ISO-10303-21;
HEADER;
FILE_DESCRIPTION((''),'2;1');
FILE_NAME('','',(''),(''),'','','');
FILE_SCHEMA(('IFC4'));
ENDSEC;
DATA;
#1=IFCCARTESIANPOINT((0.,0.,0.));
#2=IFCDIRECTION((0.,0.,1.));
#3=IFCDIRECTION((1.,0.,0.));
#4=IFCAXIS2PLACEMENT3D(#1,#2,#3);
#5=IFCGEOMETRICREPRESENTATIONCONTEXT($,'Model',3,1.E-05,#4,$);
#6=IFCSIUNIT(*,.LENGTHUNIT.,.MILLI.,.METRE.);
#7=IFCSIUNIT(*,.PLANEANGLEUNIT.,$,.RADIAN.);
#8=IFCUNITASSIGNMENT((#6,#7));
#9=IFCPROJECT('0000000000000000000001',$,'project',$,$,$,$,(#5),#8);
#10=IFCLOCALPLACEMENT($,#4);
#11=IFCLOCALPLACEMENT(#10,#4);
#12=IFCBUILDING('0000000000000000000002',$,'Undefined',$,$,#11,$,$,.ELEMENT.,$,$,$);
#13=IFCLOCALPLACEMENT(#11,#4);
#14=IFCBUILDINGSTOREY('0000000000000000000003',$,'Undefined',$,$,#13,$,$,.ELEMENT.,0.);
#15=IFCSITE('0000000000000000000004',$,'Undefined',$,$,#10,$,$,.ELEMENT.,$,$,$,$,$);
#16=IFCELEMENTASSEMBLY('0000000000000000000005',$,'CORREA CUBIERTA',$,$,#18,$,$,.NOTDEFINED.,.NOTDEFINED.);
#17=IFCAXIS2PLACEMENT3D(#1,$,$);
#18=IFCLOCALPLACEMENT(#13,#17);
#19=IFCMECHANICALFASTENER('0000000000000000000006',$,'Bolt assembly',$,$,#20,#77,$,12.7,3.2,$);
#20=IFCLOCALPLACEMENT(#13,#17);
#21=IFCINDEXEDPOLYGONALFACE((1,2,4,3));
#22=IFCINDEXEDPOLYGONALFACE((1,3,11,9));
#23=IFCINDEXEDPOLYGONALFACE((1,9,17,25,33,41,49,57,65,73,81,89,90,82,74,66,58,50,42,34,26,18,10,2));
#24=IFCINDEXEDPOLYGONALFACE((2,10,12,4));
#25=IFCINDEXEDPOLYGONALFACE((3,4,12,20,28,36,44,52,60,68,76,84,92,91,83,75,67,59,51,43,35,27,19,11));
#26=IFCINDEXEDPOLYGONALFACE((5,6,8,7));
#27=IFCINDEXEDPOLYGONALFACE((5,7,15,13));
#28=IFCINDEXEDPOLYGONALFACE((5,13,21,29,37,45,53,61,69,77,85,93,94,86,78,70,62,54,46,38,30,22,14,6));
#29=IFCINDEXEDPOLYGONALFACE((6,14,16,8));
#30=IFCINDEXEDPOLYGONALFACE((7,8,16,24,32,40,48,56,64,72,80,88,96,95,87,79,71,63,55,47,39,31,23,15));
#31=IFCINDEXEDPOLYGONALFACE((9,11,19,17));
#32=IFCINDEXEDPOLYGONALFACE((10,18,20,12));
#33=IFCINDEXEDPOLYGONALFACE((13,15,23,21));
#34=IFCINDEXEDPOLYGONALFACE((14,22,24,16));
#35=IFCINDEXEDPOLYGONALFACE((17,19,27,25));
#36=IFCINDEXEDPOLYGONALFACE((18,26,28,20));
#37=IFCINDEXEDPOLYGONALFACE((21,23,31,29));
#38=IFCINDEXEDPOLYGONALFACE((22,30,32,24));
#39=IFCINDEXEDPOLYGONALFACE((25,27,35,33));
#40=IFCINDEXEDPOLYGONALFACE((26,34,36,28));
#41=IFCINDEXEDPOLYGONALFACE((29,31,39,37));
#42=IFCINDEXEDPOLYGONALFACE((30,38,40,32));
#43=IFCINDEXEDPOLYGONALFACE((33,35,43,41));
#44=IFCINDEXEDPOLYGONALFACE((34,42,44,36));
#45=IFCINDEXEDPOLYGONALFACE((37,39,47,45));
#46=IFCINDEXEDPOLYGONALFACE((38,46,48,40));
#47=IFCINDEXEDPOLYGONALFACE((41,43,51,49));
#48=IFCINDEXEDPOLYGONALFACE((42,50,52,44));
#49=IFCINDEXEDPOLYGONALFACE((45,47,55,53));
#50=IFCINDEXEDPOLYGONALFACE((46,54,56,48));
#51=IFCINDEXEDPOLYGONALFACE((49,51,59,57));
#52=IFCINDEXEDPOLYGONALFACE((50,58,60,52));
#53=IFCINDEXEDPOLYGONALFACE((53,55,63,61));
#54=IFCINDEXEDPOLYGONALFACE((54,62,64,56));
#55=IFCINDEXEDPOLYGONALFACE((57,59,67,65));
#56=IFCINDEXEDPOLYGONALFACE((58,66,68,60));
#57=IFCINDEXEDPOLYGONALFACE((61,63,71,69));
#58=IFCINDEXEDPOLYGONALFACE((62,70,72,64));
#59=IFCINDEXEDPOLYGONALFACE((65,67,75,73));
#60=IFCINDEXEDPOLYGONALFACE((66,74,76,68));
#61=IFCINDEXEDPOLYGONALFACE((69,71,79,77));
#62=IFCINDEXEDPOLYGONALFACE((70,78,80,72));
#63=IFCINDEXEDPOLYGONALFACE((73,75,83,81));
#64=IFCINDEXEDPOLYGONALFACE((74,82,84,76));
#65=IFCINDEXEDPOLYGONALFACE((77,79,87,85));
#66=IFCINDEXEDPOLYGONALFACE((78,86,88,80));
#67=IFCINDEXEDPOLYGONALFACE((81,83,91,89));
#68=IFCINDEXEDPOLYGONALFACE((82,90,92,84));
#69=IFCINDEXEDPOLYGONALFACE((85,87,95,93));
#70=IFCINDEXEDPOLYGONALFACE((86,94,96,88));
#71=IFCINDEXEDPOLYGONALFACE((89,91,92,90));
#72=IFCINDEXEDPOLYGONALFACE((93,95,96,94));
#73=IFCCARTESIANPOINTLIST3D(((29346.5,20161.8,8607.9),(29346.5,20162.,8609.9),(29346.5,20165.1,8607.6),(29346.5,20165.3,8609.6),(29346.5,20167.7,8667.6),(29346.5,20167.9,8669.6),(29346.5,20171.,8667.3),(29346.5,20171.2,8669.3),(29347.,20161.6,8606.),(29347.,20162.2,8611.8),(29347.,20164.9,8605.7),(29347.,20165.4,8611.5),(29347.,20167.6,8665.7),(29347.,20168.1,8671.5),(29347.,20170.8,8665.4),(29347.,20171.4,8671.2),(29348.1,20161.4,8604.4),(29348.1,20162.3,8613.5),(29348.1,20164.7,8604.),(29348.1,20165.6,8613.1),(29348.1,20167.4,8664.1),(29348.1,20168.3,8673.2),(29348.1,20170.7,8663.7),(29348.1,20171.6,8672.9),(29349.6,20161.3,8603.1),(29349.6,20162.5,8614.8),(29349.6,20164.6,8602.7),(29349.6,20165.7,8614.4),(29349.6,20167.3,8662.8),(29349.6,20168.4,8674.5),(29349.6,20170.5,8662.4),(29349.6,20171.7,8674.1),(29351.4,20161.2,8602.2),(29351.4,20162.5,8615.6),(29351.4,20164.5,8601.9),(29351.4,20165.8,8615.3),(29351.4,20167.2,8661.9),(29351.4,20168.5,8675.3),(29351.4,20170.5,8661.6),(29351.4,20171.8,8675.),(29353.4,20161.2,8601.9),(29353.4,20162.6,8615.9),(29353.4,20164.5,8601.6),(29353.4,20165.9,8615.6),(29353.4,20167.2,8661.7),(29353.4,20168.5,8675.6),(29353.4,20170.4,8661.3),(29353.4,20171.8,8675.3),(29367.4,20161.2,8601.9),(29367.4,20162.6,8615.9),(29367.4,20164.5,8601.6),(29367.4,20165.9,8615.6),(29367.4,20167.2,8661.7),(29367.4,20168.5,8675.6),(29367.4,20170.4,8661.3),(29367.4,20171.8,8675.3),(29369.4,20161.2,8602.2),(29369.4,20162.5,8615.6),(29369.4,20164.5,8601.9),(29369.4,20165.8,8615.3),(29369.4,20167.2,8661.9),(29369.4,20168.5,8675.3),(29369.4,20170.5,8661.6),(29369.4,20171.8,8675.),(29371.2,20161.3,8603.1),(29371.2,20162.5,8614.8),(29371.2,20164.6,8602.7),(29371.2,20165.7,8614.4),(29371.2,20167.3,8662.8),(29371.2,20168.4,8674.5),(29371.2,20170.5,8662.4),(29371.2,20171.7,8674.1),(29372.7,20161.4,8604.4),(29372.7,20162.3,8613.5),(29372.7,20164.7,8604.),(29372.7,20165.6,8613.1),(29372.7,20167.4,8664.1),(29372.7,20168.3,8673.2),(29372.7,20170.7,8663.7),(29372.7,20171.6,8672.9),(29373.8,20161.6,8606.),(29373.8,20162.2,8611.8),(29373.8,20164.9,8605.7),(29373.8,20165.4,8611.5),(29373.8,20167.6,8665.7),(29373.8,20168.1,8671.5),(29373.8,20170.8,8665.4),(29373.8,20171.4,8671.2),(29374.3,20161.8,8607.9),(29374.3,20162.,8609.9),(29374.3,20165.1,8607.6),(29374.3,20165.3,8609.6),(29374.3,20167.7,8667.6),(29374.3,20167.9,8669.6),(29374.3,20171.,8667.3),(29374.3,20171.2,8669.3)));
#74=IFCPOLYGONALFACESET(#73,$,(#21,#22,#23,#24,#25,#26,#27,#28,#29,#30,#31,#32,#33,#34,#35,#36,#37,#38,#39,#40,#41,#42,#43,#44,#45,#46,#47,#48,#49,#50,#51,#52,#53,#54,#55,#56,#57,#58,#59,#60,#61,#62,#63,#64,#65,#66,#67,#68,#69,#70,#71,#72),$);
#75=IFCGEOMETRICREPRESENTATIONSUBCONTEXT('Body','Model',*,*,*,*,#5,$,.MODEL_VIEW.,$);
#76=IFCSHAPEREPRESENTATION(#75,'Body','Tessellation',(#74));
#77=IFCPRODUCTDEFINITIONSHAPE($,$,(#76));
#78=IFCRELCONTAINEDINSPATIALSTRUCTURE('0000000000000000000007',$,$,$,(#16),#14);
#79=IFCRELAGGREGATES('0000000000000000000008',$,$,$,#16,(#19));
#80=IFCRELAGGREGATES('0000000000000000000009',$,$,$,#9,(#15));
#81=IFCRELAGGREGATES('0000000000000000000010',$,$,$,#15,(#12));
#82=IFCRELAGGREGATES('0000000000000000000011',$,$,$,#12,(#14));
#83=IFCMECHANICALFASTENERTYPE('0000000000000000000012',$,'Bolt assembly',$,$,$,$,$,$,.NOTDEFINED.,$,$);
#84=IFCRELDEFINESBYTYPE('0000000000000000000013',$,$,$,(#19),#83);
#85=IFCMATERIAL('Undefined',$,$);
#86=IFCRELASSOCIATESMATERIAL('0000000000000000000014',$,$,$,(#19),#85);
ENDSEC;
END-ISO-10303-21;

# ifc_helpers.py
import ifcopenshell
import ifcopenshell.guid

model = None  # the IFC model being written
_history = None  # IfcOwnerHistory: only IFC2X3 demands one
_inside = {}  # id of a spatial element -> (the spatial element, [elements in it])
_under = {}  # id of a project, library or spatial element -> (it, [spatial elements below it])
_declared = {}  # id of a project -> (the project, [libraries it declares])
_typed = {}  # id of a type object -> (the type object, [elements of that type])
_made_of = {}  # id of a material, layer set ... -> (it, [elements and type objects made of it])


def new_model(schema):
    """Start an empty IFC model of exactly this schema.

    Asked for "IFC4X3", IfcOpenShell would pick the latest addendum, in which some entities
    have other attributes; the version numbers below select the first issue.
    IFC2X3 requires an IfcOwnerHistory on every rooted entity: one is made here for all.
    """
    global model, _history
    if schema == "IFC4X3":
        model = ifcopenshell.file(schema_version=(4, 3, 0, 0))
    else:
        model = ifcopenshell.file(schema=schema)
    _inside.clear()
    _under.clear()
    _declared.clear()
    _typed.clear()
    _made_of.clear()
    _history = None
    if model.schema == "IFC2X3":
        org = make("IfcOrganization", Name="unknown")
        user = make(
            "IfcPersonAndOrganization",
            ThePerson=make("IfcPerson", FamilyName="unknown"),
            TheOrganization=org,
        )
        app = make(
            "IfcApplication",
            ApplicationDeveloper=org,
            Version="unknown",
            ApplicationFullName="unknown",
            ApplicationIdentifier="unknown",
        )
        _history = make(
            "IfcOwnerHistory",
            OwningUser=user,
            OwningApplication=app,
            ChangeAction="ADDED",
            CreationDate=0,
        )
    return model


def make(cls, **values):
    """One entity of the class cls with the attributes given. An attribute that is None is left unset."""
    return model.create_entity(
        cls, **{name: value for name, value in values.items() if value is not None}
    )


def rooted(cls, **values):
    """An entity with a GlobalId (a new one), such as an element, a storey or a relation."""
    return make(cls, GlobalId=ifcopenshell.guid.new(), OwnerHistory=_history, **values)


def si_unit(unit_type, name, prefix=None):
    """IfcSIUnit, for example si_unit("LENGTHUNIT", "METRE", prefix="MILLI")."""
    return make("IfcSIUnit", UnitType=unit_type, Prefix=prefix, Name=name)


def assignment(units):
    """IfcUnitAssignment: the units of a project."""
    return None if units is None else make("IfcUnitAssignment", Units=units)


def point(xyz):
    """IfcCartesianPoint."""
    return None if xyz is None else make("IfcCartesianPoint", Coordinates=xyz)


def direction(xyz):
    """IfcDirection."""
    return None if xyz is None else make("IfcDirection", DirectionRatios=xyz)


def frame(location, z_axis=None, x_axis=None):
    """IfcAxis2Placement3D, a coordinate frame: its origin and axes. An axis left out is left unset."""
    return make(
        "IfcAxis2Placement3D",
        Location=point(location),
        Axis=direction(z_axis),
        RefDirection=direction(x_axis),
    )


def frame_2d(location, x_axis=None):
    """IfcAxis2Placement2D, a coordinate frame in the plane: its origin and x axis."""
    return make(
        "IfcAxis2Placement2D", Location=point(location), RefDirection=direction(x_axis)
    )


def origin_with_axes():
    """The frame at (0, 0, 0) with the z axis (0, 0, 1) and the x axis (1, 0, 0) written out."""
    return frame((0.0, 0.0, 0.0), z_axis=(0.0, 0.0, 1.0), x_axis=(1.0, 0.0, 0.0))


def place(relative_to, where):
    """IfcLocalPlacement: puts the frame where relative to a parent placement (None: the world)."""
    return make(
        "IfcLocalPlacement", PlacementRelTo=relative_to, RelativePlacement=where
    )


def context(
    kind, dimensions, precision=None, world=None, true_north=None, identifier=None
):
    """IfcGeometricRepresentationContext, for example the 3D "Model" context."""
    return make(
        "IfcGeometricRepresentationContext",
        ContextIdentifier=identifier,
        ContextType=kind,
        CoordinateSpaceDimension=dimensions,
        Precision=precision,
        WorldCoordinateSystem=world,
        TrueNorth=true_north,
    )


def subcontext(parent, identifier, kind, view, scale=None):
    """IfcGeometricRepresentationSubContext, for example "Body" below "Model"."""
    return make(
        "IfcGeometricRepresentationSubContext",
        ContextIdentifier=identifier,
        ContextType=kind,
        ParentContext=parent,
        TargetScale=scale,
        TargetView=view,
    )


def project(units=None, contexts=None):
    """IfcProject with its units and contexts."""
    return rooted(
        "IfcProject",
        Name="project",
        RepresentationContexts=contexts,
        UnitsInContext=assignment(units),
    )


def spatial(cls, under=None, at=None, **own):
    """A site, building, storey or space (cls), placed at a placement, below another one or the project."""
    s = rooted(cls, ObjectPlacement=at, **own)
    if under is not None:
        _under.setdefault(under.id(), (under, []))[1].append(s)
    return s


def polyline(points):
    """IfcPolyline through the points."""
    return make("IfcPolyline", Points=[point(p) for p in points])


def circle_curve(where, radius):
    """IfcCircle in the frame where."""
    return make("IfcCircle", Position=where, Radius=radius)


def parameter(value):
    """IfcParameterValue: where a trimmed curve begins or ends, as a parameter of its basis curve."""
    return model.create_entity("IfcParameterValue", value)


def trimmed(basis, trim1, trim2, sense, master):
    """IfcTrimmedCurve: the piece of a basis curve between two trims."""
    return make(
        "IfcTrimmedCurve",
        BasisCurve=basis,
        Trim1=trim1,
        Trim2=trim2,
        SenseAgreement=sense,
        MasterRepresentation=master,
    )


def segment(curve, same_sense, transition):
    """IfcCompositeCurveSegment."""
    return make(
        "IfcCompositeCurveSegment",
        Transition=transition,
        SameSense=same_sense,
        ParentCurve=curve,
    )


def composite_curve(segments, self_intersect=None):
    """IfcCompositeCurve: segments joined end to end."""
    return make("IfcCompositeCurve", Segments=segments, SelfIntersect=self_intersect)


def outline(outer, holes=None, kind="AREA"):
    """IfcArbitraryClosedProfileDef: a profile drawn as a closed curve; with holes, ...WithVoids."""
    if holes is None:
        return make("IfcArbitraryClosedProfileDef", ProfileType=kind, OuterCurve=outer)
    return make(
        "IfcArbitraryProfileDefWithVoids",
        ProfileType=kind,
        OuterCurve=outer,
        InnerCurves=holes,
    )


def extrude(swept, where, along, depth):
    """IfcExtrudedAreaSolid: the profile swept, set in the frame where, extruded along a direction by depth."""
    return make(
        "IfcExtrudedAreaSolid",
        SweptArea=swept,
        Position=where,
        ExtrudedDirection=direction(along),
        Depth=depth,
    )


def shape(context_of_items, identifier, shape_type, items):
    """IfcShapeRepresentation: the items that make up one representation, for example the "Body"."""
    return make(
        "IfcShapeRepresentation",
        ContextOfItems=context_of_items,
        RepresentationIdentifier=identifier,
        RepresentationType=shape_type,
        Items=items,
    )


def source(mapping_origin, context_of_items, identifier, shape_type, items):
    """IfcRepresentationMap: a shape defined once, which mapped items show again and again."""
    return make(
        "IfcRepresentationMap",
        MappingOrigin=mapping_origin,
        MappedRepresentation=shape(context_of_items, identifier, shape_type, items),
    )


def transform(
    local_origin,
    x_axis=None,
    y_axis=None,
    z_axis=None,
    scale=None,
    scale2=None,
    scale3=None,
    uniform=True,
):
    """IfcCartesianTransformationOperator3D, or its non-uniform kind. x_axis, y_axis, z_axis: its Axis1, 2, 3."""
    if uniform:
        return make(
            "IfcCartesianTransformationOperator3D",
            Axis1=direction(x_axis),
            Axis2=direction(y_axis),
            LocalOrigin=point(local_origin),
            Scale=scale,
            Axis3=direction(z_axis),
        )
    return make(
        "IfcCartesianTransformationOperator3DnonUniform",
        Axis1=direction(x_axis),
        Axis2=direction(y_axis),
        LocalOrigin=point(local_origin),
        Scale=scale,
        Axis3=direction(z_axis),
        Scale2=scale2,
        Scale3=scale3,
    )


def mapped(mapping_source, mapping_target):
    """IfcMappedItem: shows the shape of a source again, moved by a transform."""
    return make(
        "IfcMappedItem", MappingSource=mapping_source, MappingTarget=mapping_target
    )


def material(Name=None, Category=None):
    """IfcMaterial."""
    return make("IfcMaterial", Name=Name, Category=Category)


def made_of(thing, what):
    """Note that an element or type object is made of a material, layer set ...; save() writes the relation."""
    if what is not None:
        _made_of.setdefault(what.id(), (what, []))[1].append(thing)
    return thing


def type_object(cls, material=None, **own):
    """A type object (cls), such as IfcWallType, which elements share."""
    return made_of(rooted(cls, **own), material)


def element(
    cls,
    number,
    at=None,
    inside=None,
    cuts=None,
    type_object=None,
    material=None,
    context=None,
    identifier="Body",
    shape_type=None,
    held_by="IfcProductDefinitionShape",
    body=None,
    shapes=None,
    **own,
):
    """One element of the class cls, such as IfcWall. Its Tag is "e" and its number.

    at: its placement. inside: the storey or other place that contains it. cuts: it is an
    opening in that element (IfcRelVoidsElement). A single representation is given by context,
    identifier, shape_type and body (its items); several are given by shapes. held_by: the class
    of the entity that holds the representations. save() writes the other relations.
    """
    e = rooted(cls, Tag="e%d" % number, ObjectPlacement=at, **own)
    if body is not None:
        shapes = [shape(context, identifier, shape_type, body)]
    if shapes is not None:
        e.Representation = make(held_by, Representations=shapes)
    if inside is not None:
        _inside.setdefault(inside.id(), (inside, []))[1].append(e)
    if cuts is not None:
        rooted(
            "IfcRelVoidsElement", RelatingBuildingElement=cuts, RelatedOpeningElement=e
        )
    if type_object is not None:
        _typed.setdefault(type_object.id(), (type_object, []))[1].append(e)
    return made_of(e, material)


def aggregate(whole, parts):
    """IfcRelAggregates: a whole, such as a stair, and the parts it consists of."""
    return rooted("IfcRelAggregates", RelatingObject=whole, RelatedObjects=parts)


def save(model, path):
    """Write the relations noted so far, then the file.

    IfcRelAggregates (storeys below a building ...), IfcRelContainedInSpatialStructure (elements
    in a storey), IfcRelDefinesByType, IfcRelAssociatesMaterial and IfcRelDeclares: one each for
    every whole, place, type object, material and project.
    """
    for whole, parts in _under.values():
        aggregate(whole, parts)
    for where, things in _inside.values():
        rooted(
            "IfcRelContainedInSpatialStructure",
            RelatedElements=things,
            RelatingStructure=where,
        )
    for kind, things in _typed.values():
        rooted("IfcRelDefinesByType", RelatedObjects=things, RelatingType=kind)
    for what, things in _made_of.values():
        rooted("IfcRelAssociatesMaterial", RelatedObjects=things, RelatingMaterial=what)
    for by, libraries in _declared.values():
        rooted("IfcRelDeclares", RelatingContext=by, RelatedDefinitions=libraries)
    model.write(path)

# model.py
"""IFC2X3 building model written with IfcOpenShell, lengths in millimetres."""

from ifc_helpers import new_model, si_unit, frame, frame_2d, origin_with_axes, place, context, subcontext, project, spatial, polyline, circle_curve, parameter, trimmed, segment, composite_curve, outline, extrude, source, transform, mapped, material, type_object, element, aggregate, save


model = new_model("IFC2X3")

# Units and contexts
model_context = context("Model", 3, precision=1e-05, world=origin_with_axes())
body_context = subcontext(model_context, "Body", "Model", "MODEL_VIEW")
ifc_project = project(units=[si_unit("LENGTHUNIT", "METRE", prefix="MILLI"), si_unit("PLANEANGLEUNIT", "RADIAN")], contexts=[model_context])

# Site, building, storey
site_placement = place(None, origin_with_axes())
site = spatial("IfcSite", under=ifc_project, at=site_placement, Name="Undefined", CompositionType="ELEMENT")
building_placement = place(site_placement, origin_with_axes())
building = spatial("IfcBuilding", under=site, at=building_placement, Name="Undefined", CompositionType="ELEMENT")
storey_placement = place(building_placement, origin_with_axes())
storey = spatial("IfcBuildingStorey", under=building, at=storey_placement, Name="Undefined", CompositionType="ELEMENT", Elevation=0.0)

# Shared definitions
ifc_material_1 = material(Name="Undefined")
mechanical_fastener_type = type_object("IfcMechanicalFastenerType", Name="Bolt assembly")

# Element assembly, mechanical fastener
assembly_1_placement = place(storey_placement, origin_with_axes())
assembly_1 = element("IfcElementAssembly", 1, at=assembly_1_placement, inside=storey, Name="CORREA CUBIERTA", AssemblyPlace="NOTDEFINED", PredefinedType="NOTDEFINED")
shared_shape_1 = source(origin_with_axes(), body_context, "Body", "SweptSolid", [
    extrude(outline(composite_curve([segment(polyline([(7.0, 7.0), (7.0, -7.0)]), True, "CONTINUOUS"), segment(trimmed(circle_curve(frame_2d((0.0, -7.0), x_axis=(1.0, 0.0)), 7.0), [parameter(0.0)], [parameter(3.141593)], False, "PARAMETER"), True, "CONTINUOUS"), segment(polyline([(-7.0, -7.0), (-7.0, 7.0)]), True, "CONTINUOUS"), segment(trimmed(circle_curve(frame_2d((0.0, 7.0), x_axis=(-1.0, 0.0)), 7.0), [parameter(0.0)], [parameter(3.141593)], False, "PARAMETER"), True, "DISCONTINUOUS")], self_intersect=False)), frame((0.0, 0.0, 0.0), z_axis=(0.0, 1.0, 0.0), x_axis=(1.0, 0.0, 0.0)), (0.0, 0.0, 1.0), 3.3),
])
mechanical_fastener_1_placement = place(assembly_1_placement, frame((29360.4, 20167.8, 8668.6), z_axis=(1.0, 0.0, 0.0), x_axis=(0.0, -0.099503, -0.995037)))
mechanical_fastener_1 = element("IfcMechanicalFastener", 2, at=mechanical_fastener_1_placement, type_object=mechanical_fastener_type, material=ifc_material_1, Name="Bolt assembly", NominalDiameter=12.7, NominalLength=3.2, context=body_context, shape_type="MappedRepresentation", body=[
    mapped(shared_shape_1, transform((0.0, 0.0, 0.0))),
    mapped(shared_shape_1, transform((60.0, 0.0, 0.0))),
])

aggregate(assembly_1, [mechanical_fastener_1])

save(model, "model.ifc")
